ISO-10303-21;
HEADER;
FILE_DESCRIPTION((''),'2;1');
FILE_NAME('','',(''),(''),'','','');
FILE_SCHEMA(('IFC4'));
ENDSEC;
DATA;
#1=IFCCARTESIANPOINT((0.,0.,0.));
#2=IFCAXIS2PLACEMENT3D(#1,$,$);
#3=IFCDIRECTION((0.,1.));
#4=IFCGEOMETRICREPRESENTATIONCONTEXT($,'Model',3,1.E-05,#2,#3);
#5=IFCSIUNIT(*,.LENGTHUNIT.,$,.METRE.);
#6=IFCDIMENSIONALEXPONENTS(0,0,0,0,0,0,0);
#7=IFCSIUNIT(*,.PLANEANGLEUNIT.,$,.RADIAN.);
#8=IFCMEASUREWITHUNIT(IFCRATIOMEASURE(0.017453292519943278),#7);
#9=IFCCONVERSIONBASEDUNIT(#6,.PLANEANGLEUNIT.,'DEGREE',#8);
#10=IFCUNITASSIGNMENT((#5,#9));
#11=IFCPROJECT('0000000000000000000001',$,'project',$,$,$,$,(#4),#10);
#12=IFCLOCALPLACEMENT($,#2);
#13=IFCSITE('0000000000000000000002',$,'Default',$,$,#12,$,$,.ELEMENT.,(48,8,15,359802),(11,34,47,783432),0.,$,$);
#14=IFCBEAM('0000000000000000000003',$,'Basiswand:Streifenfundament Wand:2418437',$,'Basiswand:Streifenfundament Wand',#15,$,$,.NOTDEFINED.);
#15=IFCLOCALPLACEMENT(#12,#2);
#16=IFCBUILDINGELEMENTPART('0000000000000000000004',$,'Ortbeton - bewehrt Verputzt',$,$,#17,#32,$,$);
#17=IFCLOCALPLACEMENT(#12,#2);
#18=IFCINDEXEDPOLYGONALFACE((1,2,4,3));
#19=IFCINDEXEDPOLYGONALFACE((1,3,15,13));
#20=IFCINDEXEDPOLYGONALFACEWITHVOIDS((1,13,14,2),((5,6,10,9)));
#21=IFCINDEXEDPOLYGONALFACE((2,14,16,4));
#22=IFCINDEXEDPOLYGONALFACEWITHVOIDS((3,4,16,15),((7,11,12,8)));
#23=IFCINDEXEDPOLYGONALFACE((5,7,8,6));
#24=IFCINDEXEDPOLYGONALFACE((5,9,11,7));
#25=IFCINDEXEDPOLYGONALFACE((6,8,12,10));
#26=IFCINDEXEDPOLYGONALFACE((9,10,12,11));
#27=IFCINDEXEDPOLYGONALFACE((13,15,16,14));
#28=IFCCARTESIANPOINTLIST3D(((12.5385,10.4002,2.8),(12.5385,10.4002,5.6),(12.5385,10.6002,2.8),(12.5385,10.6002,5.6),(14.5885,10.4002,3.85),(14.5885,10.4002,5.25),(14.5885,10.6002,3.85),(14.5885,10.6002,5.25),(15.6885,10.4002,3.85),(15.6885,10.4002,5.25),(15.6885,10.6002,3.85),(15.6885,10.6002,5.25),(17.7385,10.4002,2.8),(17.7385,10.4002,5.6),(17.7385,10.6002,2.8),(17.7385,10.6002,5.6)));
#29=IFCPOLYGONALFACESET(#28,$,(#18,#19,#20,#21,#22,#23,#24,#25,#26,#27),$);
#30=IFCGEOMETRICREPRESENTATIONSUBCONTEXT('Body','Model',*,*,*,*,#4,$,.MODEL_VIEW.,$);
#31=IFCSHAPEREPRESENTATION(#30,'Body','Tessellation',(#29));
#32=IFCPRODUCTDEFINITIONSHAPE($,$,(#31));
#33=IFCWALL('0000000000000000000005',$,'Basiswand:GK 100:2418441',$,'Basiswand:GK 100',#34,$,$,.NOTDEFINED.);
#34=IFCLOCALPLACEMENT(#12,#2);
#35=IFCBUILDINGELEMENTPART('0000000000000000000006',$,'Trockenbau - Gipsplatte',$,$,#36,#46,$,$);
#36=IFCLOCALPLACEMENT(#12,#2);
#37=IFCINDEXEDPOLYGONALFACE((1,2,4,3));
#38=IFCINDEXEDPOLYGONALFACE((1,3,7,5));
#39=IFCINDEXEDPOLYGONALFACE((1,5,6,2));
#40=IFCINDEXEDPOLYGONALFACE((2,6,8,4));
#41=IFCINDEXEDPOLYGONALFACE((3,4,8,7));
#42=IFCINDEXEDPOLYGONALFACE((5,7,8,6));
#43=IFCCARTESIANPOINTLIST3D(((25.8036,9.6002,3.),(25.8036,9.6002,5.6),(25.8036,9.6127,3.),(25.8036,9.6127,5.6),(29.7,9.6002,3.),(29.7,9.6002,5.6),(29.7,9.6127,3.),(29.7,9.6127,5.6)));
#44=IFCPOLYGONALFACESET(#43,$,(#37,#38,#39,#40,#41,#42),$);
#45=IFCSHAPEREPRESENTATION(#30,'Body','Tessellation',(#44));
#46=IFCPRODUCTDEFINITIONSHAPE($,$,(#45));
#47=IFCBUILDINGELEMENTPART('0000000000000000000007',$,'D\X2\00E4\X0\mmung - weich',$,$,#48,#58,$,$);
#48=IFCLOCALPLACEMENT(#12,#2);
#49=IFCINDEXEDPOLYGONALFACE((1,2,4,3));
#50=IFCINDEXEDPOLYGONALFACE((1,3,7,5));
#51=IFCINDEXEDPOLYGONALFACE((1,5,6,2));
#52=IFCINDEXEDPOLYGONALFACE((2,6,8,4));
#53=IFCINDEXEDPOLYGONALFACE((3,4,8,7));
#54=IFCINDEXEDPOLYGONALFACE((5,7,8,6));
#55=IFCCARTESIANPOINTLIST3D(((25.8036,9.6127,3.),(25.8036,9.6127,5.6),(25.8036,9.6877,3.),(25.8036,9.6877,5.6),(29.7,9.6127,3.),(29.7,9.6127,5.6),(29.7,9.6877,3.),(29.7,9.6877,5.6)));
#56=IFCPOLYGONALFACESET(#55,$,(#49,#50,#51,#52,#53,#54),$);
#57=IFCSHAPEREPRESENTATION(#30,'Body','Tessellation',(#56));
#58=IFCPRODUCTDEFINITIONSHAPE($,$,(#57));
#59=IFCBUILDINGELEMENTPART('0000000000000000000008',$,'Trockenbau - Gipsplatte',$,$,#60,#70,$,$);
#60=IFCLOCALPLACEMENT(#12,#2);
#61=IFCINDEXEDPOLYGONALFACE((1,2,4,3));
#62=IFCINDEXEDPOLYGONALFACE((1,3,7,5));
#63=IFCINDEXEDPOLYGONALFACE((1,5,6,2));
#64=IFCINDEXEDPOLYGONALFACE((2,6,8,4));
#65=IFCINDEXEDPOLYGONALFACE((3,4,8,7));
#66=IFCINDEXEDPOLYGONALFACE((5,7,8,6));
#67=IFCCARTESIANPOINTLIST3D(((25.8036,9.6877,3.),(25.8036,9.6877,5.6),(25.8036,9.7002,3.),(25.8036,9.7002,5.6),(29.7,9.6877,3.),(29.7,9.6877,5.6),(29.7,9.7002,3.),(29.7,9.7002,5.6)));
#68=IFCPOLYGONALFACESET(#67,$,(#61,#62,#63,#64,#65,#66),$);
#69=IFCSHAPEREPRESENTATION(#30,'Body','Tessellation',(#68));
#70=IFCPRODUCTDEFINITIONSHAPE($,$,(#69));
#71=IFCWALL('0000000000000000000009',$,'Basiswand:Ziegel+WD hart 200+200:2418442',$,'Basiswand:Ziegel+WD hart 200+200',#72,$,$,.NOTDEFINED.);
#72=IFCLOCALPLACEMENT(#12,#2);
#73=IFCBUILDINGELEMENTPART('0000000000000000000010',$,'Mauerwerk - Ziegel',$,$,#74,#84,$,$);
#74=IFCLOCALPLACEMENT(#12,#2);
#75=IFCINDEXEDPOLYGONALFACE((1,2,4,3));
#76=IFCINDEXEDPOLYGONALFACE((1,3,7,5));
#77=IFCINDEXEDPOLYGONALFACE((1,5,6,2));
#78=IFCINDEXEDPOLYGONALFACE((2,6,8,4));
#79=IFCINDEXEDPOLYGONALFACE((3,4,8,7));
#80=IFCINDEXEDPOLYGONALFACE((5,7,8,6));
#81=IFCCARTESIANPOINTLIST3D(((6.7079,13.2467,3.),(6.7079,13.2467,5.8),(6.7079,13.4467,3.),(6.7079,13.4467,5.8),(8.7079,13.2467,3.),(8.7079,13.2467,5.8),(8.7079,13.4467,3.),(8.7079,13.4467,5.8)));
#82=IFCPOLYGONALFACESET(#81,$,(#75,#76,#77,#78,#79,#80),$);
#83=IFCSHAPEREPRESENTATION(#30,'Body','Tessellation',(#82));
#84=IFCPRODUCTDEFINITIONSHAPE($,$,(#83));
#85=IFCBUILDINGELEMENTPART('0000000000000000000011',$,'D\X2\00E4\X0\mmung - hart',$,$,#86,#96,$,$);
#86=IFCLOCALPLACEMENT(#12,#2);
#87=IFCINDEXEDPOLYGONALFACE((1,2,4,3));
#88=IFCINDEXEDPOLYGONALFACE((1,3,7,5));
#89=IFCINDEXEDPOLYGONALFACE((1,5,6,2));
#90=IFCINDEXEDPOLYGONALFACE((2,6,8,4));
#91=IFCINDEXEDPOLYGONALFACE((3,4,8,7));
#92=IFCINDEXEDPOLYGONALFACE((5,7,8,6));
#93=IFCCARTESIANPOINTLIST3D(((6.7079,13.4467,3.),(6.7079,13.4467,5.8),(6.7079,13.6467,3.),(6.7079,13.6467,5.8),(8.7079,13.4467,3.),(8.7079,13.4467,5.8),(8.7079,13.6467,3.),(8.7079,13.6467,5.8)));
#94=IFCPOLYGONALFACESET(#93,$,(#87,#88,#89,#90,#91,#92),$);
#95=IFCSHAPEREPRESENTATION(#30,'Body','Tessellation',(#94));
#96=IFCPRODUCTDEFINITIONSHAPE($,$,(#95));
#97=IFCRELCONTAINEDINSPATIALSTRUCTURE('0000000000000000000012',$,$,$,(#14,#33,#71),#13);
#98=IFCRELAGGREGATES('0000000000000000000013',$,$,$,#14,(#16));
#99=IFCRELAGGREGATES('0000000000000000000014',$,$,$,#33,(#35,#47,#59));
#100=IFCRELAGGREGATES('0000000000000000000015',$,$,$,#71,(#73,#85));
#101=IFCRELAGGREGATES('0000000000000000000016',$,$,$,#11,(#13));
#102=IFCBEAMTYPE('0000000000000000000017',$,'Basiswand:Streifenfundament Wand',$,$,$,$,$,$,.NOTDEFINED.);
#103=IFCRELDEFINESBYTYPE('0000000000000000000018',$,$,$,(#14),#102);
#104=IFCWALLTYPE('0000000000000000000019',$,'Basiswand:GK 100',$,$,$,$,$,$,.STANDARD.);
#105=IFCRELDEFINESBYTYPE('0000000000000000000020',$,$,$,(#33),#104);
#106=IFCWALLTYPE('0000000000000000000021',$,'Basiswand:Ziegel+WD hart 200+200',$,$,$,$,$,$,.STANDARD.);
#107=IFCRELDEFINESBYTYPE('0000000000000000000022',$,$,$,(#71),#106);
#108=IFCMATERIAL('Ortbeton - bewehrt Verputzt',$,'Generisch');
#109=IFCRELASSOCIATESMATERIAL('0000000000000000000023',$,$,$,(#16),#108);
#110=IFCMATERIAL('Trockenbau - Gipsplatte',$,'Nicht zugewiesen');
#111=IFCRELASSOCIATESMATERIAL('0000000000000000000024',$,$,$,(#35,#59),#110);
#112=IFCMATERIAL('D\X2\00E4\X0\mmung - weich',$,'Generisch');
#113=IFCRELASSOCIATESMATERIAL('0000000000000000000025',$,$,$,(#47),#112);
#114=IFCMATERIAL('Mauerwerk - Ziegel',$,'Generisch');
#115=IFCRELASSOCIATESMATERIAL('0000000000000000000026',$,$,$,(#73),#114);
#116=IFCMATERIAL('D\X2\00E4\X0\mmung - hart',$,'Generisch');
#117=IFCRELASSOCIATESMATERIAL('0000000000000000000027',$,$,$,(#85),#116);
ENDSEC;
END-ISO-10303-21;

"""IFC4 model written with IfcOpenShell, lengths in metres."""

from ifc_helpers import new_model, entity, si_unit, converted_unit, direction, frame, origin, place, context, subcontext, project, spatial, indexed_curve, outline, extrude, material, type_object, element, aggregate, save


model = new_model("IFC4")

# Units and contexts
model_context = context("Model", 3, precision=1e-05, world=origin(), true_north=direction((0.0, 1.0)))
body_context = subcontext(model_context, "Body", "Model", "MODEL_VIEW")
ifc_project = project(units=[si_unit("LENGTHUNIT", "METRE"), converted_unit("PLANEANGLEUNIT", "DEGREE", entity("IfcRatioMeasure", 0.017453292519943278), si_unit("PLANEANGLEUNIT", "RADIAN"), dimensions=[0, 0, 0, 0, 0, 0, 0])], contexts=[model_context])

# Site
site_placement = place(None, origin())
site = spatial("IfcSite", under=ifc_project, at=site_placement, Name="Default", CompositionType="ELEMENT", RefLatitude=(48, 8, 15, 359802), RefLongitude=(11, 34, 47, 783432), RefElevation=0.0)

# Shared definitions
ifc_material_1 = material(Name="Ortbeton - bewehrt Verputzt", Category="Generisch")

# Shared definitions
beam_type_1 = type_object("IfcBeamType", Name="Basiswand:Streifenfundament Wand", PredefinedType="NOTDEFINED")

# Shared definitions
wall_type_1 = type_object("IfcWallType", Name="Basiswand:GK 100", PredefinedType="STANDARD")
ifc_material_2 = material(Name="Trockenbau - Gipsplatte", Category="Nicht zugewiesen")
ifc_material_3 = material(Name="Dämmung - weich", Category="Generisch")
wall_type_2 = type_object("IfcWallType", Name="Basiswand:Ziegel+WD hart 200+200", PredefinedType="STANDARD")
ifc_material_4 = material(Name="Mauerwerk - Ziegel", Category="Generisch")
ifc_material_5 = material(Name="Dämmung - hart", Category="Generisch")

# Beam, building element part
beam_1_placement = place(site_placement, frame((12.5385, 10.5002, 0.0)))
beam_1 = element("IfcBeam", 1, at=beam_1_placement, inside=site, type_object=beam_type_1, Name="Basiswand:Streifenfundament Wand:2418437", ObjectType="Basiswand:Streifenfundament Wand", PredefinedType="NOTDEFINED")
building_element_part_1_placement = place(beam_1_placement, origin())
building_element_part_1 = element("IfcBuildingElementPart", 2, at=building_element_part_1_placement, material=ifc_material_1, Name="Ortbeton - bewehrt Verputzt", context=body_context, shape_type="SweptSolid", body=[
    extrude(outline(indexed_curve([(-1.4, -2.6), (1.4, -2.6), (1.4, 2.6), (-1.4, 2.6), (-1.4, -2.6)], self_intersect=False), holes=[indexed_curve([(1.05, -0.55), (-0.35, -0.55), (-0.35, 0.55), (1.05, 0.55), (1.05, -0.55)], self_intersect=False)]), frame((2.6, -0.1, 4.2), z_axis=(0.0, 1.0, 0.0), x_axis=(0.0, 0.0, 1.0)), (0.0, 0.0, 1.0), 0.2),
])
aggregate(beam_1, [building_element_part_1])

# Walls, building element parts
wall_1_placement = place(site_placement, frame((25.8036, 9.6502, 0.0)))
wall_1 = element("IfcWall", 3, at=wall_1_placement, inside=site, type_object=wall_type_1, Name="Basiswand:GK 100:2418441", ObjectType="Basiswand:GK 100", PredefinedType="NOTDEFINED")
building_element_part_2_placement = place(wall_1_placement, origin())
building_element_part_2 = element("IfcBuildingElementPart", 4, at=building_element_part_2_placement, material=ifc_material_2, Name="Trockenbau - Gipsplatte", context=body_context, shape_type="SweptSolid", body=[
    extrude(outline(indexed_curve([(-0.0063, -1.9482), (0.0062, -1.9482), (0.0063, 1.9482), (-0.0062, 1.9482), (-0.0063, -1.9482)], self_intersect=False)), frame((1.9482, -0.0438, 3.0), z_axis=(0.0, 0.0, 1.0), x_axis=(0.0, -1.0, 0.0)), (0.0, 0.0, 1.0), 2.6),
])
building_element_part_3_placement = place(wall_1_placement, origin())
building_element_part_3 = element("IfcBuildingElementPart", 5, at=building_element_part_3_placement, material=ifc_material_3, Name="Dämmung - weich", context=body_context, shape_type="SweptSolid", body=[
    extrude(outline(indexed_curve([(-0.0375, -1.9482), (0.0375, -1.9482), (0.0375, 1.9482), (-0.0375, 1.9482), (-0.0375, -1.9482)], self_intersect=False)), frame((1.9482, 0.0, 3.0), z_axis=(0.0, 0.0, 1.0), x_axis=(0.0, -1.0, 0.0)), (0.0, 0.0, 1.0), 2.6),
])
building_element_part_4_placement = place(wall_1_placement, origin())
building_element_part_4 = element("IfcBuildingElementPart", 6, at=building_element_part_4_placement, material=ifc_material_2, Name="Trockenbau - Gipsplatte", context=body_context, shape_type="SweptSolid", body=[
    extrude(outline(indexed_curve([(-0.0063, -1.9482), (0.0062, -1.9482), (0.0063, 1.9482), (-0.0062, 1.9482), (-0.0063, -1.9482)], self_intersect=False)), frame((1.9482, 0.0437, 3.0), z_axis=(0.0, 0.0, 1.0), x_axis=(0.0, -1.0, 0.0)), (0.0, 0.0, 1.0), 2.6),
])
aggregate(wall_1, [building_element_part_2, building_element_part_3, building_element_part_4])
wall_2_placement = place(site_placement, frame((6.7079, 13.4467, 0.0)))
wall_2 = element("IfcWall", 7, at=wall_2_placement, inside=site, type_object=wall_type_2, Name="Basiswand:Ziegel+WD hart 200+200:2418442", ObjectType="Basiswand:Ziegel+WD hart 200+200", PredefinedType="NOTDEFINED")
building_element_part_5_placement = place(wall_2_placement, origin())
building_element_part_5 = element("IfcBuildingElementPart", 8, at=building_element_part_5_placement, material=ifc_material_4, Name="Mauerwerk - Ziegel", context=body_context, shape_type="SweptSolid", body=[
    extrude(outline(indexed_curve([(-0.1, -1.0), (0.1, -1.0), (0.1, 1.0), (-0.1, 1.0), (-0.1, -1.0)], self_intersect=False)), frame((1.0, -0.1, 3.0), z_axis=(0.0, 0.0, 1.0), x_axis=(0.0, -1.0, 0.0)), (0.0, 0.0, 1.0), 2.8),
])
building_element_part_6_placement = place(wall_2_placement, origin())
building_element_part_6 = element("IfcBuildingElementPart", 9, at=building_element_part_6_placement, material=ifc_material_5, Name="Dämmung - hart", context=body_context, shape_type="SweptSolid", body=[
    extrude(outline(indexed_curve([(-0.1, -1.0), (0.1, -1.0), (0.1, 1.0), (-0.1, 1.0), (-0.1, -1.0)], self_intersect=False)), frame((1.0, 0.1, 3.0), z_axis=(0.0, 0.0, 1.0), x_axis=(0.0, -1.0, 0.0)), (0.0, 0.0, 1.0), 2.8),
])
aggregate(wall_2, [building_element_part_5, building_element_part_6])

save(model, "model.ifc")
